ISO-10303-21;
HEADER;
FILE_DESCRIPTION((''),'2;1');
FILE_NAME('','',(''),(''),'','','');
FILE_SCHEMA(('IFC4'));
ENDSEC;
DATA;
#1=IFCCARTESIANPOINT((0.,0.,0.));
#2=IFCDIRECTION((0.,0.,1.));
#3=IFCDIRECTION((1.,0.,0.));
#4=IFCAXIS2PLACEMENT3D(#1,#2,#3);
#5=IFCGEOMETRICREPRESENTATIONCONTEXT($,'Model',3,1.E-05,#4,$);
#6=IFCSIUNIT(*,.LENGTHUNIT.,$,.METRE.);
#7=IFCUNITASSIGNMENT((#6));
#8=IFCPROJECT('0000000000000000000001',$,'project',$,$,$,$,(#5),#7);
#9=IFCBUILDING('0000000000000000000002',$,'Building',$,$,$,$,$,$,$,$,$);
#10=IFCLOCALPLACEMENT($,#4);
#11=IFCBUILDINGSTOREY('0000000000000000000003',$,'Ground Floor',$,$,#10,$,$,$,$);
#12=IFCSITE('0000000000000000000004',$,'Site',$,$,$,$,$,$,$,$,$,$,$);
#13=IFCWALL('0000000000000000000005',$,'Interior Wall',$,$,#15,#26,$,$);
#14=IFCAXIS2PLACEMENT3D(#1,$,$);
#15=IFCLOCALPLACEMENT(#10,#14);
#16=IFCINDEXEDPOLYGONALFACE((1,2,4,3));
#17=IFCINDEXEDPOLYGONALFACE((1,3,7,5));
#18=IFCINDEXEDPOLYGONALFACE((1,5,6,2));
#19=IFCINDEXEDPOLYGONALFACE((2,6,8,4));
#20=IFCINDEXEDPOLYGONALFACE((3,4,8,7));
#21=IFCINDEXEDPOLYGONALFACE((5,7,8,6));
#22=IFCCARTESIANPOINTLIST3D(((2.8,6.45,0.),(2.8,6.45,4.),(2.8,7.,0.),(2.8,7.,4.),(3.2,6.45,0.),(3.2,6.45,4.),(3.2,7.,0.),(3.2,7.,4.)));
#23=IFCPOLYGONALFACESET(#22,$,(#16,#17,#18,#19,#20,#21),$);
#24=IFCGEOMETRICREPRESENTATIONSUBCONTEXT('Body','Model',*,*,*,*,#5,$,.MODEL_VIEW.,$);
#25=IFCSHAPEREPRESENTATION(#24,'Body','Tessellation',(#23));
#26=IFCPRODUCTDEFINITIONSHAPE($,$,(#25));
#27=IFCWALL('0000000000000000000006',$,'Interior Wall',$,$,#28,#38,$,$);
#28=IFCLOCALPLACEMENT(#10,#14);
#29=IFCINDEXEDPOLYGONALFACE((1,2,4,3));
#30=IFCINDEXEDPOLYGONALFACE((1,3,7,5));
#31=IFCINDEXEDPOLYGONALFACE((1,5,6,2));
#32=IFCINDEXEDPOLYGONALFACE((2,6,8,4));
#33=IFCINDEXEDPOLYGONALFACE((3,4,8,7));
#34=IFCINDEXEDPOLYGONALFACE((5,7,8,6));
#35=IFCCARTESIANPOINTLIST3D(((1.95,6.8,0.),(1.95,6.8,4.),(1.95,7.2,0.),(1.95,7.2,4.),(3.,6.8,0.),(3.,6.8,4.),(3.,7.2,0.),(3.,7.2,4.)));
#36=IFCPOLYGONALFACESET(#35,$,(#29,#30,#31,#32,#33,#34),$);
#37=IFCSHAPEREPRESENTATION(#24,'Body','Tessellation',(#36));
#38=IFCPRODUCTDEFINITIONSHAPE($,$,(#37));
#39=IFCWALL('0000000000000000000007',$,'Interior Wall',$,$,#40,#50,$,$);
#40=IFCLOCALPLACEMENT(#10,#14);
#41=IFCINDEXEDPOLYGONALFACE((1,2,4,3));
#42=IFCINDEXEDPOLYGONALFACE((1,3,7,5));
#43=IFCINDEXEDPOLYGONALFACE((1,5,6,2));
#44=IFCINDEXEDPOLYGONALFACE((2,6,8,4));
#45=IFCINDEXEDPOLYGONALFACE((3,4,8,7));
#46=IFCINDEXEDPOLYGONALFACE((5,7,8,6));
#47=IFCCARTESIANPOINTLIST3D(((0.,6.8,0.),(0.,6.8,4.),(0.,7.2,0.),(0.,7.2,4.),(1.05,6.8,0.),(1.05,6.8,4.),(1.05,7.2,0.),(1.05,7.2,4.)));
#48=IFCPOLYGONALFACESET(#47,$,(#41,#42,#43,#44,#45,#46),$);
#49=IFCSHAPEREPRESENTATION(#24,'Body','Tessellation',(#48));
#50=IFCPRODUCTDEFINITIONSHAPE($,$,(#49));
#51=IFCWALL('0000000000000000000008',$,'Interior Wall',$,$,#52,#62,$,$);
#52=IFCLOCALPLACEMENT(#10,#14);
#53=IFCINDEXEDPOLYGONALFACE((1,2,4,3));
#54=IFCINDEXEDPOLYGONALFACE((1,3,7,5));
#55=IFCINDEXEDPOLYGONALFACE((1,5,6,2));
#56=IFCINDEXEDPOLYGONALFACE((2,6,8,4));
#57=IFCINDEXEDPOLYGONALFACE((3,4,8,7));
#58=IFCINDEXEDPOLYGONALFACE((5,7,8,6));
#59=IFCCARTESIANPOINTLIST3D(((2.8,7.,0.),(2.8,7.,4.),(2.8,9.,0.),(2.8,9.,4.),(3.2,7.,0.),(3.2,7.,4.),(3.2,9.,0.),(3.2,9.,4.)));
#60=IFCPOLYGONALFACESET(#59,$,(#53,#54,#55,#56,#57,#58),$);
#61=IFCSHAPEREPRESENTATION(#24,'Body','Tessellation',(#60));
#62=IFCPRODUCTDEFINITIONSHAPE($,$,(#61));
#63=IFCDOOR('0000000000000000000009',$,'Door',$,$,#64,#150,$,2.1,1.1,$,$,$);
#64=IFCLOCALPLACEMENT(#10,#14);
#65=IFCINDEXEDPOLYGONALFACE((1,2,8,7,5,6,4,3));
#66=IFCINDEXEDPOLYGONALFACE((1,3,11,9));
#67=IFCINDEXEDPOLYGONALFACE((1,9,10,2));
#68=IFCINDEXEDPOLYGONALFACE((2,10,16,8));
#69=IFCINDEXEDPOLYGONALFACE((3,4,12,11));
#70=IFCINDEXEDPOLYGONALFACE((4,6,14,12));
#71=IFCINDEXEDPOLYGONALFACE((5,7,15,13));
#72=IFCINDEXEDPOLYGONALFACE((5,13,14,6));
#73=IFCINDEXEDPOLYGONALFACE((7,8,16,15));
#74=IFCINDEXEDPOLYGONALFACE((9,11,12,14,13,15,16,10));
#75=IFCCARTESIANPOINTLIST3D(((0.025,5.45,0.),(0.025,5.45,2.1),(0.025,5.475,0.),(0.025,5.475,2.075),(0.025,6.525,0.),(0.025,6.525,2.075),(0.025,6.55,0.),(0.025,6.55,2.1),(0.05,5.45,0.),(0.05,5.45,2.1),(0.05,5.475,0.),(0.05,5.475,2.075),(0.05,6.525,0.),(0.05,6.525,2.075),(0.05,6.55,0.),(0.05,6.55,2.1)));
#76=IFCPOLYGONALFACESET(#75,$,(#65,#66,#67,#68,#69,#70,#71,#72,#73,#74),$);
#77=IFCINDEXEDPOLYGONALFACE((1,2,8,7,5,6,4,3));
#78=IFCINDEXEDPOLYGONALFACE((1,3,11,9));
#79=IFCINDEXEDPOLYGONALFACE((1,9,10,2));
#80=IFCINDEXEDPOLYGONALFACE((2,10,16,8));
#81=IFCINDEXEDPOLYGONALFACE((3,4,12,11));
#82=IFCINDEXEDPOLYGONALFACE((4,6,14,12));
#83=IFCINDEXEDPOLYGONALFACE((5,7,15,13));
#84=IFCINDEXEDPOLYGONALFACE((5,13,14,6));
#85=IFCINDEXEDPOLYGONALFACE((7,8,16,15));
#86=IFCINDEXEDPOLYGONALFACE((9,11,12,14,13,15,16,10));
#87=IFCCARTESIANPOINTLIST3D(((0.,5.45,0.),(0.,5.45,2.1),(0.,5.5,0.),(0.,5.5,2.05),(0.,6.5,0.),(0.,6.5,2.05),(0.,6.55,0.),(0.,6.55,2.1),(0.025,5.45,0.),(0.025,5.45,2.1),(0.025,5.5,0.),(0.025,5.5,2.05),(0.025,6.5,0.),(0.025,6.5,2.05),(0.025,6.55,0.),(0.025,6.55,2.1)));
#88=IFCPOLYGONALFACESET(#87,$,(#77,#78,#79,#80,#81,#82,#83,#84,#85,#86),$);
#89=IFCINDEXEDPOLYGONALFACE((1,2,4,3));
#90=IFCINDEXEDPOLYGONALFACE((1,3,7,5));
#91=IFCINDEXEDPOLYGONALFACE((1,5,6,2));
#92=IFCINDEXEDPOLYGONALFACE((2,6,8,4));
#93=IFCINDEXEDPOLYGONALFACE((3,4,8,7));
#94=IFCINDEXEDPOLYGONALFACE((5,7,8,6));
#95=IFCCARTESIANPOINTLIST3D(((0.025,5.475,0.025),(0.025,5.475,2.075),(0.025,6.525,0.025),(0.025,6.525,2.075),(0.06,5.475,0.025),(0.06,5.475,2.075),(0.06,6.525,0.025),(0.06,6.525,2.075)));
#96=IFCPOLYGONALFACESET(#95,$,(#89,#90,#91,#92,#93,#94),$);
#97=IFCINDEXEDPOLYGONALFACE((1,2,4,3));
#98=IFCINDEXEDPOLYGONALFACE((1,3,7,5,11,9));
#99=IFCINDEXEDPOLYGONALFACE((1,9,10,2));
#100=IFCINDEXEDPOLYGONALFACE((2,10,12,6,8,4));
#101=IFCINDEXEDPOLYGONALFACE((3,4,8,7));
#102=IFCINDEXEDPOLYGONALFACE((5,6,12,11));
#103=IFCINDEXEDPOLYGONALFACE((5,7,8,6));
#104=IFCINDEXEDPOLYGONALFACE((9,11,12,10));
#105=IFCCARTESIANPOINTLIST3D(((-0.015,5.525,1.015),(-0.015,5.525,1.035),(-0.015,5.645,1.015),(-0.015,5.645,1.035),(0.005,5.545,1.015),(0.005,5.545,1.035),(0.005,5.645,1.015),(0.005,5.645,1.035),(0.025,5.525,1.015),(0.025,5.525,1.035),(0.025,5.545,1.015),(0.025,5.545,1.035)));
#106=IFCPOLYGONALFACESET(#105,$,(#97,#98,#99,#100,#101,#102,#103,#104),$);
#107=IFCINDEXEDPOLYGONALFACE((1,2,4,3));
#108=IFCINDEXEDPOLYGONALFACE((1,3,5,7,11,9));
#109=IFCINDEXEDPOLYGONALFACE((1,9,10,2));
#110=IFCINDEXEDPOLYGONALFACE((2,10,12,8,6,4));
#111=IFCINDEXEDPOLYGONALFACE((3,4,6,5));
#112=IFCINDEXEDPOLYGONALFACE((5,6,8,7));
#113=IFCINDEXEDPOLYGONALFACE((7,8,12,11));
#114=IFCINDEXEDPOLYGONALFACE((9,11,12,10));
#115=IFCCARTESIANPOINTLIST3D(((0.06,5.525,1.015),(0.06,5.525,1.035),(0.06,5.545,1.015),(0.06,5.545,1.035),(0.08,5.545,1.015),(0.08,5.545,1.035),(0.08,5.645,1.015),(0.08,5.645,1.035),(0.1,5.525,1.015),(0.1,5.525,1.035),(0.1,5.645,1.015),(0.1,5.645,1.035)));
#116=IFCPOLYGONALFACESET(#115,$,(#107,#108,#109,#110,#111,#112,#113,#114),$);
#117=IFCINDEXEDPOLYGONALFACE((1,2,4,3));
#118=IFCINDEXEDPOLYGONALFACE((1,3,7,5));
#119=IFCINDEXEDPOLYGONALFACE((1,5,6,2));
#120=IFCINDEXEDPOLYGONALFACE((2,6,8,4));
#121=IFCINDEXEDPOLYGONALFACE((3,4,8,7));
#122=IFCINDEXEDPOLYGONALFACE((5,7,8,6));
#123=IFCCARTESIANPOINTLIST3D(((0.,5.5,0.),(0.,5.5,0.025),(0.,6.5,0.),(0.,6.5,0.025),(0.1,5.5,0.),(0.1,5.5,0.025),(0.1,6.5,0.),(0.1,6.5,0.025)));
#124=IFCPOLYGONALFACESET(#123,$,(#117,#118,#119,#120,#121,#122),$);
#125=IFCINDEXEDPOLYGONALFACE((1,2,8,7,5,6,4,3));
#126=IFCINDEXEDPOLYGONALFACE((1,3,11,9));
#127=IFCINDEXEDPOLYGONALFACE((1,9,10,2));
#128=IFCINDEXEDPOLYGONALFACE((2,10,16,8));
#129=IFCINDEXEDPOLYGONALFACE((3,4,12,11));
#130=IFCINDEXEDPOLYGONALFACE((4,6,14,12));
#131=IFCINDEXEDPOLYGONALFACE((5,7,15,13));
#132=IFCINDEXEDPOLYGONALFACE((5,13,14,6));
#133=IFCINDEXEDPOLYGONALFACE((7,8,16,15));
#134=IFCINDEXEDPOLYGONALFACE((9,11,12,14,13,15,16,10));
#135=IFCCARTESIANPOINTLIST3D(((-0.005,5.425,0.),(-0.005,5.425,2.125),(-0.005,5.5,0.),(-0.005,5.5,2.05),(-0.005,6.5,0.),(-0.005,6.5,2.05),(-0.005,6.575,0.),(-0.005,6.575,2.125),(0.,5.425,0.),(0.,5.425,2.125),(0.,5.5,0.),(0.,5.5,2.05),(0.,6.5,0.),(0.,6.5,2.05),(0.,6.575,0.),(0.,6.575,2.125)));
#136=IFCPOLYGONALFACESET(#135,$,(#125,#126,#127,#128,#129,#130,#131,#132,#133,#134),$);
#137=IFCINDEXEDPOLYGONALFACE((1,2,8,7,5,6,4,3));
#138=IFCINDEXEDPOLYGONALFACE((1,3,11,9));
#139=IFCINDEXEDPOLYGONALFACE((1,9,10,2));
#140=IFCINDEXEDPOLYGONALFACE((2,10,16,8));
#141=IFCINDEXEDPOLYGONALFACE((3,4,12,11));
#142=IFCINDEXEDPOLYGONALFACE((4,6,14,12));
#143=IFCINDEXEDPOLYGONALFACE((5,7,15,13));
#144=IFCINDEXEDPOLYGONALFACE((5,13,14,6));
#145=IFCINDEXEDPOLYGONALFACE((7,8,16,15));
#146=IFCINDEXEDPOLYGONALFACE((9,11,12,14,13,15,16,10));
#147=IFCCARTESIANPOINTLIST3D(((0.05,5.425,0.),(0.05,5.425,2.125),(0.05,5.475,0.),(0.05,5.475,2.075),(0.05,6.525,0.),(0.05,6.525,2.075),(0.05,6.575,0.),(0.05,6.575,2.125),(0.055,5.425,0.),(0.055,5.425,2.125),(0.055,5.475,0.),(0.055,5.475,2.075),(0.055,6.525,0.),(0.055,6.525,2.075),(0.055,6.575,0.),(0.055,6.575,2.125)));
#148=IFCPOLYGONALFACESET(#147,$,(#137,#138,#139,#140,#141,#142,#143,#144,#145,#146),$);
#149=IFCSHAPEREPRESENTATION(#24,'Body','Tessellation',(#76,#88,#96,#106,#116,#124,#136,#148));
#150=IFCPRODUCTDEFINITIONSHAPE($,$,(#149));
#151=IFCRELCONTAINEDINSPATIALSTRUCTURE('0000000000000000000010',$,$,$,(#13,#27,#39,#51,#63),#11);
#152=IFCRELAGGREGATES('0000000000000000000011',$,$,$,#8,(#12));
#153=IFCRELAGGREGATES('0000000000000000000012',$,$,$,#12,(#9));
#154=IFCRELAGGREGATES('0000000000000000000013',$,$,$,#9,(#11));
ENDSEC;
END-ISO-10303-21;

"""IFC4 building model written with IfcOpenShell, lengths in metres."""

from ifc_helpers import new_model, si_unit, frame, origin_with_axes, place, context, subcontext, project, spatial, line, indexed_curve, outline, extrude, element, save


model = new_model("IFC4")

# Units and contexts
model_context = context("Model", 3, precision=1e-05, world=origin_with_axes())
body_context = subcontext(model_context, "Body", "Model", "MODEL_VIEW")
ifc_project = project(units=[si_unit("LENGTHUNIT", "METRE")], contexts=[model_context])

# Site, building, storey
site = spatial("IfcSite", under=ifc_project, Name="Site")
building = spatial("IfcBuilding", under=site, Name="Building")
storey_placement = place(None, origin_with_axes())
storey = spatial("IfcBuildingStorey", under=building, at=storey_placement, Name="Ground Floor")

# Walls
for number, where, z_axis, x_axis, name in (
    (1, (3.0, 6.45, 0.0), (0.0, 0.0, 1.0), (0.0, 1.0, 0.0), "Interior Wall"),
):
    element("IfcWall", number, at=place(storey_placement, frame(where, z_axis=z_axis, x_axis=x_axis)), inside=storey, Name=name, context=body_context, shape_type="SweptSolid", body=[
        extrude(outline(indexed_curve([(0.0, 0.0), (0.0, 0.4), (0.55, 0.4), (0.55, 0.0), (0.0, 0.0)], self_intersect=False)), frame((0.0, -0.2, 0.0), z_axis=(0.0, 0.0, 1.0), x_axis=(1.0, 0.0, 0.0)), (0.0, 0.0, 1.0), 4.0),
    ])
for number, where, z_axis, x_axis, name in (
    (2, (3.0, 7.0, 0.0), (0.0, 0.0, 1.0), (-1.0, 0.0, 0.0), "Interior Wall"),
    (3, (1.05, 7.0, 0.0), (0.0, 0.0, 1.0), (-1.0, 0.0, 0.0), "Interior Wall"),
):
    element("IfcWall", number, at=place(storey_placement, frame(where, z_axis=z_axis, x_axis=x_axis)), inside=storey, Name=name, context=body_context, shape_type="SweptSolid", body=[
        extrude(outline(indexed_curve([(0.0, 0.0), (0.0, 0.4), (1.05, 0.4), (1.05, 0.0), (0.0, 0.0)], self_intersect=False)), frame((0.0, -0.2, 0.0), z_axis=(0.0, 0.0, 1.0), x_axis=(1.0, 0.0, 0.0)), (0.0, 0.0, 1.0), 4.0),
    ])
wall_1_placement = place(storey_placement, frame((3.0, 7.0, 0.0), z_axis=(0.0, 0.0, 1.0), x_axis=(0.0, 1.0, 0.0)))
element("IfcWall", 4, at=wall_1_placement, inside=storey, Name="Interior Wall", context=body_context, shape_type="SweptSolid", body=[
    extrude(outline(indexed_curve([(0.0, 0.0), (0.0, 0.4), (2.0, 0.4), (2.0, 0.0), (0.0, 0.0)], self_intersect=False)), frame((0.0, -0.2, 0.0), z_axis=(0.0, 0.0, 1.0), x_axis=(1.0, 0.0, 0.0)), (0.0, 0.0, 1.0), 4.0),
])

# Door
door_1_placement = place(storey_placement, frame((0.0, 6.55, 0.0), z_axis=(0.0, 0.0, 1.0), x_axis=(0.0, -1.0, 0.0)))
element("IfcDoor", 5, at=door_1_placement, inside=storey, Name="Door", OverallHeight=2.1, OverallWidth=1.1, context=body_context, shape_type="SweptSolid", body=[
    extrude(outline(indexed_curve([(0.0, 0.0), (0.0, 2.1), (1.1, 2.1), (1.1, 0.0), (1.075, 0.0), (1.075, 2.075), (0.025, 2.075), (0.025, 0.0)], segments=[line(1, 2, 3, 4, 5, 6, 7, 8, 1)])), frame((0.0, 0.025, 0.0), z_axis=(0.0, -1.0, 0.0), x_axis=(1.0, 0.0, 0.0)), (0.0, 0.0, -1.0), 0.025),
    extrude(outline(indexed_curve([(0.0, 0.0), (0.0, 2.1), (1.1, 2.1), (1.1, 0.0), (1.05, 0.0), (1.05, 2.05), (0.05, 2.05), (0.05, 0.0)], segments=[line(1, 2, 3, 4, 5, 6, 7, 8, 1)])), frame((0.0, 0.0, 0.0), z_axis=(0.0, -1.0, 0.0), x_axis=(1.0, 0.0, 0.0)), (0.0, 0.0, -1.0), 0.025),
    extrude(outline(indexed_curve([(0.0, 0.0), (1.05, 0.0), (1.05, 0.035), (0.0, 0.035)], segments=[line(1, 2, 3, 4, 1)])), frame((0.025, 0.025, 0.025), z_axis=(0.0, 0.0, 1.0), x_axis=(1.0, 0.0, 0.0)), (0.0, 0.0, 1.0), 2.05),
    extrude(outline(indexed_curve([(0.0, 0.0), (0.0, -0.04), (-0.12, -0.04), (-0.12, -0.02), (-0.02, -0.02), (-0.02, 0.0)], segments=[line(1, 2, 3, 4, 5, 6, 1)])), frame((1.025, 0.025, 1.015), z_axis=(0.0, 0.0, 1.0), x_axis=(1.0, 0.0, 0.0)), (0.0, 0.0, 1.0), 0.02),
    extrude(outline(indexed_curve([(0.0, 0.0), (0.0, 0.04), (-0.12, 0.04), (-0.12, 0.02), (-0.02, 0.02), (-0.02, 0.0)], segments=[line(1, 2, 3, 4, 5, 6, 1)])), frame((1.025, 0.06, 1.015), z_axis=(0.0, 0.0, 1.0), x_axis=(1.0, 0.0, 0.0)), (0.0, 0.0, 1.0), 0.02),
    extrude(outline(indexed_curve([(0.0, 0.0), (1.0, 0.0), (1.0, 0.1), (0.0, 0.1)], segments=[line(1, 2, 3, 4, 1)])), frame((0.05, 0.0, 0.0), z_axis=(0.0, 0.0, 1.0), x_axis=(1.0, 0.0, 0.0)), (0.0, 0.0, 1.0), 0.025),
    extrude(outline(indexed_curve([(0.0, 0.0), (0.0, 2.125), (1.15, 2.125), (1.15, 0.0), (1.075, 0.0), (1.075, 2.05), (0.075, 2.05), (0.075, 0.0)], segments=[line(1, 2, 3, 4, 5, 6, 7, 8, 1)])), frame((-0.025, -0.005, 0.0), z_axis=(0.0, -1.0, 0.0), x_axis=(1.0, 0.0, 0.0)), (0.0, 0.0, -1.0), 0.005),
    extrude(outline(indexed_curve([(0.0, 0.0), (0.0, 2.125), (1.15, 2.125), (1.15, 0.0), (1.1, 0.0), (1.1, 2.075), (0.05, 2.075), (0.05, 0.0)], segments=[line(1, 2, 3, 4, 5, 6, 7, 8, 1)])), frame((-0.025, 0.05, 0.0), z_axis=(0.0, -1.0, 0.0), x_axis=(1.0, 0.0, 0.0)), (0.0, 0.0, -1.0), 0.005),
])

save(model, "model.ifc")
